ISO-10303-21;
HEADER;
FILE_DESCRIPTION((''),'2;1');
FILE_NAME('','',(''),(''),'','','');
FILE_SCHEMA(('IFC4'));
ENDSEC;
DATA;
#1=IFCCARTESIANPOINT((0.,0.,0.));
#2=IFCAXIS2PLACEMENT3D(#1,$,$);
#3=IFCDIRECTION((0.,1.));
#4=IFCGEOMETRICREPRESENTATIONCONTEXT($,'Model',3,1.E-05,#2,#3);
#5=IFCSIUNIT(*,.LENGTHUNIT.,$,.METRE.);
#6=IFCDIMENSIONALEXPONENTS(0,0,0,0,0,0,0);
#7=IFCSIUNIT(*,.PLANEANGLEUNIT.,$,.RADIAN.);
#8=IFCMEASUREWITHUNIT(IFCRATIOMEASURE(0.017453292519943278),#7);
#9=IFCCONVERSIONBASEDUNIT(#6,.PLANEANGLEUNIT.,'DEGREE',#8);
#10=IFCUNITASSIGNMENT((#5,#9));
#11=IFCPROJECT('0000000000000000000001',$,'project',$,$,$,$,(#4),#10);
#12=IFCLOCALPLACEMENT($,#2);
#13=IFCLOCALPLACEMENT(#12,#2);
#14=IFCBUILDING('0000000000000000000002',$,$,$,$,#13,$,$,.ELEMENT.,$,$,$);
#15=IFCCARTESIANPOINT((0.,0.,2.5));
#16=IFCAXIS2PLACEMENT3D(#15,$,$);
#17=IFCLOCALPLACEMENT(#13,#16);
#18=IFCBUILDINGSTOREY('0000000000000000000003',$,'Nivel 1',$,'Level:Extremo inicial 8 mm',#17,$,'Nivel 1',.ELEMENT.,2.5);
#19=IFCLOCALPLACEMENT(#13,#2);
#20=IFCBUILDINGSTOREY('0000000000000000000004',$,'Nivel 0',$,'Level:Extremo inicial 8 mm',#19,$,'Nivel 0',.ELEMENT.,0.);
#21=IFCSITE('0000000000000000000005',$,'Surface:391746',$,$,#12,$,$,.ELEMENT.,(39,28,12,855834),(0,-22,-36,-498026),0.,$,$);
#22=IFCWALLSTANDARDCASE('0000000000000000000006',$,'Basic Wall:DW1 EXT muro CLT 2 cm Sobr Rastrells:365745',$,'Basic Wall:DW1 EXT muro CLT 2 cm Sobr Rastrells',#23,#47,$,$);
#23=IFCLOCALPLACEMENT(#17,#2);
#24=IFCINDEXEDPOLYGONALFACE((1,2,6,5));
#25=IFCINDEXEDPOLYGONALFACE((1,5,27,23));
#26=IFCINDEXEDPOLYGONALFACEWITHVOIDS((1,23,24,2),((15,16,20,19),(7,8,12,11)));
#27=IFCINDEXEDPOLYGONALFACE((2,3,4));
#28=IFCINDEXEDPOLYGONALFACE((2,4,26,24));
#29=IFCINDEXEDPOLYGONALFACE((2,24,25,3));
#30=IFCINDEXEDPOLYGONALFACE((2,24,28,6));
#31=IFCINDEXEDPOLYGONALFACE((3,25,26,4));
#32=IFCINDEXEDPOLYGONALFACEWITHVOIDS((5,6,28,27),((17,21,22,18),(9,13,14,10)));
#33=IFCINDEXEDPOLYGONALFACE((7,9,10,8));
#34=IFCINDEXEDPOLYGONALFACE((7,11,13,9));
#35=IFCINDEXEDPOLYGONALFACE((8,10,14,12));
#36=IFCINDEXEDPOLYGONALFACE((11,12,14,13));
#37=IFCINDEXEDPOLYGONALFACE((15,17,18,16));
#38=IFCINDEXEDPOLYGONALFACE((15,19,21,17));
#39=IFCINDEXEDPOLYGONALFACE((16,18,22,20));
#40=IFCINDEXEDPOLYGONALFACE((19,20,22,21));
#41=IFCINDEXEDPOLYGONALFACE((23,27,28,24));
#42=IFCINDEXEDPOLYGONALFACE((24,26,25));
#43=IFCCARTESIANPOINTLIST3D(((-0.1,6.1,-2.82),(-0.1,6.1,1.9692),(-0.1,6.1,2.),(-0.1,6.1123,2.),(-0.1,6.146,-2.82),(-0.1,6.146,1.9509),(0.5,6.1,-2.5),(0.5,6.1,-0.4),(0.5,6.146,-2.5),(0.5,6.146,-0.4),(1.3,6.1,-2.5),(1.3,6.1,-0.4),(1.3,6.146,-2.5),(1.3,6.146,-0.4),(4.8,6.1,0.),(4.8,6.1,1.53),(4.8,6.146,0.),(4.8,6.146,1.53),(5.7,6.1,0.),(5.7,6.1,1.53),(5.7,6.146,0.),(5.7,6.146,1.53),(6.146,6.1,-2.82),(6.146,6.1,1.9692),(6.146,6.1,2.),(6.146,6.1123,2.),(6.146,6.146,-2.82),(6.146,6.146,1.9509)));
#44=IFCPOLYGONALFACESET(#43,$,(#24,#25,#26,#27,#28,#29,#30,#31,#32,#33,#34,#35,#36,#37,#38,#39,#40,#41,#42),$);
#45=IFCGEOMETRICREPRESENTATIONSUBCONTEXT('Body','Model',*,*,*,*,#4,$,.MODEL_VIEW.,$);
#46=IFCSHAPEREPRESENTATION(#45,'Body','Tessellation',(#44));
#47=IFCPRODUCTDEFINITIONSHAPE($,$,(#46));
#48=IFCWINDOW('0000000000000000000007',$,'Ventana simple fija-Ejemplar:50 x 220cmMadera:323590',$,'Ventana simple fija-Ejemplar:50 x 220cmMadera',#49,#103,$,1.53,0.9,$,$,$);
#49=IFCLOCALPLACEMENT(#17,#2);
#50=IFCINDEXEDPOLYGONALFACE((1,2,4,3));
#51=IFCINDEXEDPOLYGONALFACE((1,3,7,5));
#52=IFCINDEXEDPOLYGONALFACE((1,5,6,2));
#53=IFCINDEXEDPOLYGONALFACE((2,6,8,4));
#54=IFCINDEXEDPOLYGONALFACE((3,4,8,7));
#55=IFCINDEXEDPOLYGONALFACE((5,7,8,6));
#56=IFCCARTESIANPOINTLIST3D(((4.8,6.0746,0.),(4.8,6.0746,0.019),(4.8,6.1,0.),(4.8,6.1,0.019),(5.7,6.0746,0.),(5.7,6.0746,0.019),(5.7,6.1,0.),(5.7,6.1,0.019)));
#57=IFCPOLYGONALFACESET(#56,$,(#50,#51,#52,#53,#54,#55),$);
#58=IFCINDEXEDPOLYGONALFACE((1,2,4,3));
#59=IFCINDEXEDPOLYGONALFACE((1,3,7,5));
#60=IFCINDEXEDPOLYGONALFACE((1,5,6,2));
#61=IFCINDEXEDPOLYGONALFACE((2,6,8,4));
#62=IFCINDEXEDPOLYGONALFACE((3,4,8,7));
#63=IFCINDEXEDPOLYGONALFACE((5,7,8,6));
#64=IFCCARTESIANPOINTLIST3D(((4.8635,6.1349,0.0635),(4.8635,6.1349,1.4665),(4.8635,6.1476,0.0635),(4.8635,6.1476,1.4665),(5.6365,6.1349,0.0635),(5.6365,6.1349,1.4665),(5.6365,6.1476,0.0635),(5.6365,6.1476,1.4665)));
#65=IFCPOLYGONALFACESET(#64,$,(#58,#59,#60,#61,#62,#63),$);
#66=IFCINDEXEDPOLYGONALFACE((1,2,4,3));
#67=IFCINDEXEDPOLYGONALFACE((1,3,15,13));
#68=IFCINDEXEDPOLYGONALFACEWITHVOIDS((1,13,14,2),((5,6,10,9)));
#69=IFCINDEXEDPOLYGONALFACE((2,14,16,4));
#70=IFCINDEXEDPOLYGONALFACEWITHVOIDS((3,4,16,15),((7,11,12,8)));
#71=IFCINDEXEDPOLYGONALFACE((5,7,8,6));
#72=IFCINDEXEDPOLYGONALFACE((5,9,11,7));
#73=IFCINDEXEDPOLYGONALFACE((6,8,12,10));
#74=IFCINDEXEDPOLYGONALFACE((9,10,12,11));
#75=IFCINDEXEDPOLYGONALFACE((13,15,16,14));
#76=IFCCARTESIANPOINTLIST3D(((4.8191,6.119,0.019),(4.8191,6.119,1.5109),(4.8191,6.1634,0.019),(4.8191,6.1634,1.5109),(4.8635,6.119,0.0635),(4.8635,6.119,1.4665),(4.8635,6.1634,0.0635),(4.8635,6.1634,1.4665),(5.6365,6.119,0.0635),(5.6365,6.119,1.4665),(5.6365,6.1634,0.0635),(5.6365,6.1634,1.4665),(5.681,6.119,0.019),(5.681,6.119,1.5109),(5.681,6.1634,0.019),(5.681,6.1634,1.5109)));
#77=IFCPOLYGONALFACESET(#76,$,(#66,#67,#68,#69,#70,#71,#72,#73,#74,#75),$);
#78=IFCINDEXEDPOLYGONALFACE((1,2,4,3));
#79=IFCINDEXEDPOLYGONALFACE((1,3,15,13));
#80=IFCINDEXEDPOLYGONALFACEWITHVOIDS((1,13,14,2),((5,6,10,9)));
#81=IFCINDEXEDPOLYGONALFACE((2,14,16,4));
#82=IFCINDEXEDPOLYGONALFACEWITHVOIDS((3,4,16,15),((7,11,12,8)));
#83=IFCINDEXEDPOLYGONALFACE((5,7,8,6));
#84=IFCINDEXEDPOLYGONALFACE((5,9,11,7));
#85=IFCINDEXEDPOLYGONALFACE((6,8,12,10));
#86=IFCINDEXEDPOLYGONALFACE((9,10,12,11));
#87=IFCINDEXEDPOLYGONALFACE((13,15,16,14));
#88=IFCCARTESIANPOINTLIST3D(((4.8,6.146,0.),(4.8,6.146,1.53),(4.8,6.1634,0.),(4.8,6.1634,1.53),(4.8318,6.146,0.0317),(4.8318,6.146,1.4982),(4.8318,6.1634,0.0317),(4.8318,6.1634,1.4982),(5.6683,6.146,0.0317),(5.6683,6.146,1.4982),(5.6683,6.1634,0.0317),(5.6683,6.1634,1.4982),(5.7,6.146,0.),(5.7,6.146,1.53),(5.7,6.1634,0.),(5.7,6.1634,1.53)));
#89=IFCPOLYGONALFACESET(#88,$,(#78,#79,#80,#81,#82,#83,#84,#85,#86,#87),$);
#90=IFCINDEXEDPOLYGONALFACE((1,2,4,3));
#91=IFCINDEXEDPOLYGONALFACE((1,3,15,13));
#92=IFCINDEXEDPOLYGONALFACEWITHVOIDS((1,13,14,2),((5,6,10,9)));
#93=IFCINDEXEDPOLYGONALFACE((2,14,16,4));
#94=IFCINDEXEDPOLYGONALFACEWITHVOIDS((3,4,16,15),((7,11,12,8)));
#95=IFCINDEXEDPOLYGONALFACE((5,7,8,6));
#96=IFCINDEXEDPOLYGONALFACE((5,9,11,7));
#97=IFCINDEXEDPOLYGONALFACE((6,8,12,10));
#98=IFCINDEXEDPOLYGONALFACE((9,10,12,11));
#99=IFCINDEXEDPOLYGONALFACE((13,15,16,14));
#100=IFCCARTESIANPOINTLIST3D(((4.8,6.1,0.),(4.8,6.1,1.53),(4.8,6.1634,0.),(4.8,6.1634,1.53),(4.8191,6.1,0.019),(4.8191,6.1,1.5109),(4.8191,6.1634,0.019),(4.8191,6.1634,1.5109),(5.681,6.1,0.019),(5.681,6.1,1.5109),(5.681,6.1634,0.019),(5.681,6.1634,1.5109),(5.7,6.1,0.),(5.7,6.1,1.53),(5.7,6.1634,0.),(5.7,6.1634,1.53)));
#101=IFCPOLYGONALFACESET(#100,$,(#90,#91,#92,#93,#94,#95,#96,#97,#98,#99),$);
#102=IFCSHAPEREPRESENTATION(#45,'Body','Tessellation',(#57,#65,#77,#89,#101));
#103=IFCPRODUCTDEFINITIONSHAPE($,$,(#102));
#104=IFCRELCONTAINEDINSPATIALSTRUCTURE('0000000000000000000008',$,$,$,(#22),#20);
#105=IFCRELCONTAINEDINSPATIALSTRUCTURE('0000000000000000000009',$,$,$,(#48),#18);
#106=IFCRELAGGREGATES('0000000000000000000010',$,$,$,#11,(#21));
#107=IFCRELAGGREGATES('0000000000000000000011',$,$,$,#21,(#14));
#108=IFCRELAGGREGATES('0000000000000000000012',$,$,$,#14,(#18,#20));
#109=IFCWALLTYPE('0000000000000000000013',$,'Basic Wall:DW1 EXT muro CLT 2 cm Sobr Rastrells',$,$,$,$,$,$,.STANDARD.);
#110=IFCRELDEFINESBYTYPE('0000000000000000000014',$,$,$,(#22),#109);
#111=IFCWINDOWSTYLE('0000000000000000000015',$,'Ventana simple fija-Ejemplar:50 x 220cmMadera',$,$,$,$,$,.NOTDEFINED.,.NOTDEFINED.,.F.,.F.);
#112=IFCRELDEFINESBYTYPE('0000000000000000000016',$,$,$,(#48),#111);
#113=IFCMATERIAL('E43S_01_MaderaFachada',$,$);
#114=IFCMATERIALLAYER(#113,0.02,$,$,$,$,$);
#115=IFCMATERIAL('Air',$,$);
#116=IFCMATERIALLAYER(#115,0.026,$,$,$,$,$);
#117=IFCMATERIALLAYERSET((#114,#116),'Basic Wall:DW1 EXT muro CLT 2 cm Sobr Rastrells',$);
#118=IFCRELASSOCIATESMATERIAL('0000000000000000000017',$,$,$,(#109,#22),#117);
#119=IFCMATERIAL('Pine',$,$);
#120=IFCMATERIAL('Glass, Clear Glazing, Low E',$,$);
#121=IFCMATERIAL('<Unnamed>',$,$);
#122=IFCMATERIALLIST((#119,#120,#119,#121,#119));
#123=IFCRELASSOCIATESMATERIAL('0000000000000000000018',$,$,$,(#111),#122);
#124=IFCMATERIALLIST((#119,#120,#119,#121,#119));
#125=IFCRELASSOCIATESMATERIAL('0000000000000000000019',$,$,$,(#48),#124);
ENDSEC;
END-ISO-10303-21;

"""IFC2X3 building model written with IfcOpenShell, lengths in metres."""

from ifc_helpers import new_model, entity, si_unit, converted_unit, direction, frame, frame_2d, origin, origin_2d_with_axis, place, context, subcontext, project, spatial, polyline, rectangle, outline, extrude, source, transform, mapped, material, material_list, layer, layer_set, layer_usage, type_object, type_shapes, element, fill, save


model = new_model("IFC2X3")

# Units and contexts
model_context = context("Model", 3, precision=1e-05, world=origin(), true_north=direction((0.0, 1.0)))
body_context = subcontext(model_context, "Body", "Model", "MODEL_VIEW")
ifc_project = project(units=[si_unit("LENGTHUNIT", "METRE"), converted_unit("PLANEANGLEUNIT", "DEGREE", entity("IfcRatioMeasure", 0.017453292519943278), si_unit("PLANEANGLEUNIT", "RADIAN"), dimensions=[0, 0, 0, 0, 0, 0, 0])], contexts=[model_context])

# Site, building, storey
site_placement = place(None, origin())
site = spatial("IfcSite", under=ifc_project, at=site_placement, Name="Surface:391746", CompositionType="ELEMENT", RefLatitude=(39, 28, 12, 855834), RefLongitude=(0, -22, -36, -498026), RefElevation=0.0)
building_placement = place(site_placement, origin())
building = spatial("IfcBuilding", under=site, at=building_placement, CompositionType="ELEMENT")
storey_1_placement = place(building_placement, frame((0.0, 0.0, 2.5)))
storey_1 = spatial("IfcBuildingStorey", under=building, at=storey_1_placement, Name="Nivel 1", ObjectType="Level:Extremo inicial 8 mm", LongName="Nivel 1", CompositionType="ELEMENT", Elevation=2.5)

# Shared definitions
storey_2_placement = place(building_placement, origin())
storey_2 = spatial("IfcBuildingStorey", under=building, at=storey_2_placement, Name="Nivel 0", ObjectType="Level:Extremo inicial 8 mm", LongName="Nivel 0", CompositionType="ELEMENT", Elevation=0.0)

# Wall, openings, window
ifc_material_1 = material(Name="E43S_01_MaderaFachada")
ifc_layer_1 = layer(ifc_material_1, 0.02)
ifc_material_2 = material(Name="Air")
ifc_layer_2 = layer(ifc_material_2, 0.026)
ifc_layer_set_1 = layer_set([ifc_layer_1, ifc_layer_2], Name="Basic Wall:DW1 EXT muro CLT 2 cm Sobr Rastrells")
ifc_layer_usage_1 = layer_usage(ifc_layer_set_1, "AXIS2", "NEGATIVE", 0.023)
wall_type = type_object("IfcWallType", Name="Basic Wall:DW1 EXT muro CLT 2 cm Sobr Rastrells", PredefinedType="STANDARD", material=ifc_layer_set_1)
wall_placement = place(storey_2_placement, frame((-0.1, 6.123, -0.32)))
wall = element("IfcWallStandardCase", 1, at=wall_placement, inside=storey_2, type_object=wall_type, material=ifc_layer_usage_1, Name="Basic Wall:DW1 EXT muro CLT 2 cm Sobr Rastrells:365745", ObjectType="Basic Wall:DW1 EXT muro CLT 2 cm Sobr Rastrells", context=body_context, shape_type="SweptSolid", body=[
    extrude(rectangle(XDim=6.246, YDim=0.046, at=frame_2d((3.123, 0.0), x_axis=(-1.0, 0.0))), origin(), (0.0, 0.0, 1.0), 4.82),
])
opening_1_placement = place(storey_2_placement, frame((-0.1, 6.123, -0.32)))
element("IfcOpeningElement", 2, at=opening_1_placement, cuts=wall, ObjectType="Opening", context=body_context, shape_type="SweptSolid", body=[
    extrude(rectangle(XDim=0.0495, YDim=6.246, at=frame_2d((-0.6154, 0.005), x_axis=(0.0, 1.0))), frame((3.7384, -0.0046, 4.7819), z_axis=(0.0, 0.370288, 0.928917), x_axis=(1.0, 0.0, 0.0)), (0.0, 0.0, 1.0), 0.0599),
])
opening_2_placement = place(wall_placement, origin())
element("IfcOpeningElement", 3, at=opening_2_placement, cuts=wall, ObjectType="Opening", context=body_context, shape_type="SweptSolid", body=[
    extrude(rectangle(XDim=2.1, YDim=0.8, at=frame_2d((0.0, 0.0), x_axis=(1.0, 0.0))), frame((1.0, -1.547, 1.37), z_axis=(0.0, 1.0, 0.0), x_axis=(0.0, 0.0, -1.0)), (0.0, 0.0, 1.0), 3.048),
])
opening_3_placement = place(wall_placement, frame((5.8, 0.023, 2.82)))
opening_3 = element("IfcOpeningElement", 4, at=opening_3_placement, cuts=wall, ObjectType="Opening", context=body_context, shape_type="SweptSolid", body=[
    extrude(rectangle(XDim=1.53, YDim=0.9, at=frame_2d((0.765, 0.45), x_axis=(-1.0, 0.0))), frame((0.0, 0.0, 0.0), z_axis=(0.0, -1.0, 0.0), x_axis=(0.0, 0.0, 1.0)), (0.0, 0.0, 1.0), 0.046),
])
ifc_material_3 = material(Name="Pine")
ifc_material_4 = material(Name="Glass, Clear Glazing, Low E")
ifc_material_5 = material(Name="<Unnamed>")
ifc_material_list_1 = material_list([ifc_material_3, ifc_material_4, ifc_material_3, ifc_material_5, ifc_material_3])
ifc_material_list_2 = material_list([ifc_material_3, ifc_material_4, ifc_material_3, ifc_material_5, ifc_material_3])
window_style = type_object("IfcWindowStyle", Name="Ventana simple fija-Ejemplar:50 x 220cmMadera", ConstructionType="NOTDEFINED", OperationType="NOTDEFINED", ParameterTakesPrecedence=False, Sizeable=False, material=ifc_material_list_2)
shared_shape = source(origin(), body_context, "Body", "SweptSolid", [
    extrude(rectangle(XDim=0.9, YDim=0.0254, at=origin_2d_with_axis()), frame((0.5262, 0.0587, 0.0), z_axis=(0.0, 0.0, 1.0), x_axis=(-1.0, 0.0, 0.0)), (0.0, 0.0, 1.0), 0.019),
    extrude(rectangle(XDim=0.773, YDim=0.0127, at=origin_2d_with_axis()), frame((0.5262, 0.0048, 0.0635)), (0.0, 0.0, 1.0), 1.403),
    extrude(outline(polyline([(-0.431, -0.7459), (0.431, -0.7459), (0.431, 0.7459), (-0.431, 0.7459), (-0.431, -0.7459)]), holes=[polyline([(-0.3865, -0.7015), (-0.3865, 0.7015), (0.3865, 0.7015), (0.3865, -0.7015), (-0.3865, -0.7015)])]), frame((0.5262, 0.027, 0.765), z_axis=(0.0, -1.0, 0.0), x_axis=(-1.0, 0.0, 0.0)), (0.0, 0.0, 1.0), 0.0444),
    extrude(outline(polyline([(-0.45, -0.765), (0.45, -0.765), (0.45, 0.765), (-0.45, 0.765), (-0.45, -0.765)]), holes=[polyline([(-0.4183, -0.7332), (-0.4183, 0.7332), (0.4183, 0.7332), (0.4183, -0.7332), (-0.4183, -0.7332)])]), frame((0.5262, 0.0, 0.765), z_axis=(0.0, -1.0, 0.0), x_axis=(-1.0, 0.0, 0.0)), (0.0, 0.0, 1.0), 0.0175),
    extrude(outline(polyline([(-0.765, -0.45), (0.765, -0.45), (0.765, 0.45), (-0.765, 0.45), (-0.765, -0.45)]), holes=[polyline([(-0.7459, -0.431), (-0.7459, 0.431), (0.7459, 0.431), (0.7459, -0.431), (-0.7459, -0.431)])]), frame((0.5262, 0.046, 0.765), z_axis=(0.0, -1.0, 0.0), x_axis=(0.0, 0.0, -1.0)), (0.0, 0.0, 1.0), 0.0635),
])
type_shapes(window_style, [shared_shape])
window_placement = place(opening_3_placement, frame((0.0762, 0.0, 0.0), z_axis=(0.0, 0.0, 1.0), x_axis=(-1.0, 0.0, 0.0)))
window = element("IfcWindow", 5, at=window_placement, inside=storey_1, type_object=window_style, material=ifc_material_list_1, Name="Ventana simple fija-Ejemplar:50 x 220cmMadera:323590", ObjectType="Ventana simple fija-Ejemplar:50 x 220cmMadera", OverallHeight=1.53, OverallWidth=0.9, context=body_context, shape_type="MappedRepresentation", body=[
    mapped(shared_shape, transform((0.0, 0.0, 0.0), scale=1.0)),
])
fill(opening_3, window)

save(model, "model.ifc")
